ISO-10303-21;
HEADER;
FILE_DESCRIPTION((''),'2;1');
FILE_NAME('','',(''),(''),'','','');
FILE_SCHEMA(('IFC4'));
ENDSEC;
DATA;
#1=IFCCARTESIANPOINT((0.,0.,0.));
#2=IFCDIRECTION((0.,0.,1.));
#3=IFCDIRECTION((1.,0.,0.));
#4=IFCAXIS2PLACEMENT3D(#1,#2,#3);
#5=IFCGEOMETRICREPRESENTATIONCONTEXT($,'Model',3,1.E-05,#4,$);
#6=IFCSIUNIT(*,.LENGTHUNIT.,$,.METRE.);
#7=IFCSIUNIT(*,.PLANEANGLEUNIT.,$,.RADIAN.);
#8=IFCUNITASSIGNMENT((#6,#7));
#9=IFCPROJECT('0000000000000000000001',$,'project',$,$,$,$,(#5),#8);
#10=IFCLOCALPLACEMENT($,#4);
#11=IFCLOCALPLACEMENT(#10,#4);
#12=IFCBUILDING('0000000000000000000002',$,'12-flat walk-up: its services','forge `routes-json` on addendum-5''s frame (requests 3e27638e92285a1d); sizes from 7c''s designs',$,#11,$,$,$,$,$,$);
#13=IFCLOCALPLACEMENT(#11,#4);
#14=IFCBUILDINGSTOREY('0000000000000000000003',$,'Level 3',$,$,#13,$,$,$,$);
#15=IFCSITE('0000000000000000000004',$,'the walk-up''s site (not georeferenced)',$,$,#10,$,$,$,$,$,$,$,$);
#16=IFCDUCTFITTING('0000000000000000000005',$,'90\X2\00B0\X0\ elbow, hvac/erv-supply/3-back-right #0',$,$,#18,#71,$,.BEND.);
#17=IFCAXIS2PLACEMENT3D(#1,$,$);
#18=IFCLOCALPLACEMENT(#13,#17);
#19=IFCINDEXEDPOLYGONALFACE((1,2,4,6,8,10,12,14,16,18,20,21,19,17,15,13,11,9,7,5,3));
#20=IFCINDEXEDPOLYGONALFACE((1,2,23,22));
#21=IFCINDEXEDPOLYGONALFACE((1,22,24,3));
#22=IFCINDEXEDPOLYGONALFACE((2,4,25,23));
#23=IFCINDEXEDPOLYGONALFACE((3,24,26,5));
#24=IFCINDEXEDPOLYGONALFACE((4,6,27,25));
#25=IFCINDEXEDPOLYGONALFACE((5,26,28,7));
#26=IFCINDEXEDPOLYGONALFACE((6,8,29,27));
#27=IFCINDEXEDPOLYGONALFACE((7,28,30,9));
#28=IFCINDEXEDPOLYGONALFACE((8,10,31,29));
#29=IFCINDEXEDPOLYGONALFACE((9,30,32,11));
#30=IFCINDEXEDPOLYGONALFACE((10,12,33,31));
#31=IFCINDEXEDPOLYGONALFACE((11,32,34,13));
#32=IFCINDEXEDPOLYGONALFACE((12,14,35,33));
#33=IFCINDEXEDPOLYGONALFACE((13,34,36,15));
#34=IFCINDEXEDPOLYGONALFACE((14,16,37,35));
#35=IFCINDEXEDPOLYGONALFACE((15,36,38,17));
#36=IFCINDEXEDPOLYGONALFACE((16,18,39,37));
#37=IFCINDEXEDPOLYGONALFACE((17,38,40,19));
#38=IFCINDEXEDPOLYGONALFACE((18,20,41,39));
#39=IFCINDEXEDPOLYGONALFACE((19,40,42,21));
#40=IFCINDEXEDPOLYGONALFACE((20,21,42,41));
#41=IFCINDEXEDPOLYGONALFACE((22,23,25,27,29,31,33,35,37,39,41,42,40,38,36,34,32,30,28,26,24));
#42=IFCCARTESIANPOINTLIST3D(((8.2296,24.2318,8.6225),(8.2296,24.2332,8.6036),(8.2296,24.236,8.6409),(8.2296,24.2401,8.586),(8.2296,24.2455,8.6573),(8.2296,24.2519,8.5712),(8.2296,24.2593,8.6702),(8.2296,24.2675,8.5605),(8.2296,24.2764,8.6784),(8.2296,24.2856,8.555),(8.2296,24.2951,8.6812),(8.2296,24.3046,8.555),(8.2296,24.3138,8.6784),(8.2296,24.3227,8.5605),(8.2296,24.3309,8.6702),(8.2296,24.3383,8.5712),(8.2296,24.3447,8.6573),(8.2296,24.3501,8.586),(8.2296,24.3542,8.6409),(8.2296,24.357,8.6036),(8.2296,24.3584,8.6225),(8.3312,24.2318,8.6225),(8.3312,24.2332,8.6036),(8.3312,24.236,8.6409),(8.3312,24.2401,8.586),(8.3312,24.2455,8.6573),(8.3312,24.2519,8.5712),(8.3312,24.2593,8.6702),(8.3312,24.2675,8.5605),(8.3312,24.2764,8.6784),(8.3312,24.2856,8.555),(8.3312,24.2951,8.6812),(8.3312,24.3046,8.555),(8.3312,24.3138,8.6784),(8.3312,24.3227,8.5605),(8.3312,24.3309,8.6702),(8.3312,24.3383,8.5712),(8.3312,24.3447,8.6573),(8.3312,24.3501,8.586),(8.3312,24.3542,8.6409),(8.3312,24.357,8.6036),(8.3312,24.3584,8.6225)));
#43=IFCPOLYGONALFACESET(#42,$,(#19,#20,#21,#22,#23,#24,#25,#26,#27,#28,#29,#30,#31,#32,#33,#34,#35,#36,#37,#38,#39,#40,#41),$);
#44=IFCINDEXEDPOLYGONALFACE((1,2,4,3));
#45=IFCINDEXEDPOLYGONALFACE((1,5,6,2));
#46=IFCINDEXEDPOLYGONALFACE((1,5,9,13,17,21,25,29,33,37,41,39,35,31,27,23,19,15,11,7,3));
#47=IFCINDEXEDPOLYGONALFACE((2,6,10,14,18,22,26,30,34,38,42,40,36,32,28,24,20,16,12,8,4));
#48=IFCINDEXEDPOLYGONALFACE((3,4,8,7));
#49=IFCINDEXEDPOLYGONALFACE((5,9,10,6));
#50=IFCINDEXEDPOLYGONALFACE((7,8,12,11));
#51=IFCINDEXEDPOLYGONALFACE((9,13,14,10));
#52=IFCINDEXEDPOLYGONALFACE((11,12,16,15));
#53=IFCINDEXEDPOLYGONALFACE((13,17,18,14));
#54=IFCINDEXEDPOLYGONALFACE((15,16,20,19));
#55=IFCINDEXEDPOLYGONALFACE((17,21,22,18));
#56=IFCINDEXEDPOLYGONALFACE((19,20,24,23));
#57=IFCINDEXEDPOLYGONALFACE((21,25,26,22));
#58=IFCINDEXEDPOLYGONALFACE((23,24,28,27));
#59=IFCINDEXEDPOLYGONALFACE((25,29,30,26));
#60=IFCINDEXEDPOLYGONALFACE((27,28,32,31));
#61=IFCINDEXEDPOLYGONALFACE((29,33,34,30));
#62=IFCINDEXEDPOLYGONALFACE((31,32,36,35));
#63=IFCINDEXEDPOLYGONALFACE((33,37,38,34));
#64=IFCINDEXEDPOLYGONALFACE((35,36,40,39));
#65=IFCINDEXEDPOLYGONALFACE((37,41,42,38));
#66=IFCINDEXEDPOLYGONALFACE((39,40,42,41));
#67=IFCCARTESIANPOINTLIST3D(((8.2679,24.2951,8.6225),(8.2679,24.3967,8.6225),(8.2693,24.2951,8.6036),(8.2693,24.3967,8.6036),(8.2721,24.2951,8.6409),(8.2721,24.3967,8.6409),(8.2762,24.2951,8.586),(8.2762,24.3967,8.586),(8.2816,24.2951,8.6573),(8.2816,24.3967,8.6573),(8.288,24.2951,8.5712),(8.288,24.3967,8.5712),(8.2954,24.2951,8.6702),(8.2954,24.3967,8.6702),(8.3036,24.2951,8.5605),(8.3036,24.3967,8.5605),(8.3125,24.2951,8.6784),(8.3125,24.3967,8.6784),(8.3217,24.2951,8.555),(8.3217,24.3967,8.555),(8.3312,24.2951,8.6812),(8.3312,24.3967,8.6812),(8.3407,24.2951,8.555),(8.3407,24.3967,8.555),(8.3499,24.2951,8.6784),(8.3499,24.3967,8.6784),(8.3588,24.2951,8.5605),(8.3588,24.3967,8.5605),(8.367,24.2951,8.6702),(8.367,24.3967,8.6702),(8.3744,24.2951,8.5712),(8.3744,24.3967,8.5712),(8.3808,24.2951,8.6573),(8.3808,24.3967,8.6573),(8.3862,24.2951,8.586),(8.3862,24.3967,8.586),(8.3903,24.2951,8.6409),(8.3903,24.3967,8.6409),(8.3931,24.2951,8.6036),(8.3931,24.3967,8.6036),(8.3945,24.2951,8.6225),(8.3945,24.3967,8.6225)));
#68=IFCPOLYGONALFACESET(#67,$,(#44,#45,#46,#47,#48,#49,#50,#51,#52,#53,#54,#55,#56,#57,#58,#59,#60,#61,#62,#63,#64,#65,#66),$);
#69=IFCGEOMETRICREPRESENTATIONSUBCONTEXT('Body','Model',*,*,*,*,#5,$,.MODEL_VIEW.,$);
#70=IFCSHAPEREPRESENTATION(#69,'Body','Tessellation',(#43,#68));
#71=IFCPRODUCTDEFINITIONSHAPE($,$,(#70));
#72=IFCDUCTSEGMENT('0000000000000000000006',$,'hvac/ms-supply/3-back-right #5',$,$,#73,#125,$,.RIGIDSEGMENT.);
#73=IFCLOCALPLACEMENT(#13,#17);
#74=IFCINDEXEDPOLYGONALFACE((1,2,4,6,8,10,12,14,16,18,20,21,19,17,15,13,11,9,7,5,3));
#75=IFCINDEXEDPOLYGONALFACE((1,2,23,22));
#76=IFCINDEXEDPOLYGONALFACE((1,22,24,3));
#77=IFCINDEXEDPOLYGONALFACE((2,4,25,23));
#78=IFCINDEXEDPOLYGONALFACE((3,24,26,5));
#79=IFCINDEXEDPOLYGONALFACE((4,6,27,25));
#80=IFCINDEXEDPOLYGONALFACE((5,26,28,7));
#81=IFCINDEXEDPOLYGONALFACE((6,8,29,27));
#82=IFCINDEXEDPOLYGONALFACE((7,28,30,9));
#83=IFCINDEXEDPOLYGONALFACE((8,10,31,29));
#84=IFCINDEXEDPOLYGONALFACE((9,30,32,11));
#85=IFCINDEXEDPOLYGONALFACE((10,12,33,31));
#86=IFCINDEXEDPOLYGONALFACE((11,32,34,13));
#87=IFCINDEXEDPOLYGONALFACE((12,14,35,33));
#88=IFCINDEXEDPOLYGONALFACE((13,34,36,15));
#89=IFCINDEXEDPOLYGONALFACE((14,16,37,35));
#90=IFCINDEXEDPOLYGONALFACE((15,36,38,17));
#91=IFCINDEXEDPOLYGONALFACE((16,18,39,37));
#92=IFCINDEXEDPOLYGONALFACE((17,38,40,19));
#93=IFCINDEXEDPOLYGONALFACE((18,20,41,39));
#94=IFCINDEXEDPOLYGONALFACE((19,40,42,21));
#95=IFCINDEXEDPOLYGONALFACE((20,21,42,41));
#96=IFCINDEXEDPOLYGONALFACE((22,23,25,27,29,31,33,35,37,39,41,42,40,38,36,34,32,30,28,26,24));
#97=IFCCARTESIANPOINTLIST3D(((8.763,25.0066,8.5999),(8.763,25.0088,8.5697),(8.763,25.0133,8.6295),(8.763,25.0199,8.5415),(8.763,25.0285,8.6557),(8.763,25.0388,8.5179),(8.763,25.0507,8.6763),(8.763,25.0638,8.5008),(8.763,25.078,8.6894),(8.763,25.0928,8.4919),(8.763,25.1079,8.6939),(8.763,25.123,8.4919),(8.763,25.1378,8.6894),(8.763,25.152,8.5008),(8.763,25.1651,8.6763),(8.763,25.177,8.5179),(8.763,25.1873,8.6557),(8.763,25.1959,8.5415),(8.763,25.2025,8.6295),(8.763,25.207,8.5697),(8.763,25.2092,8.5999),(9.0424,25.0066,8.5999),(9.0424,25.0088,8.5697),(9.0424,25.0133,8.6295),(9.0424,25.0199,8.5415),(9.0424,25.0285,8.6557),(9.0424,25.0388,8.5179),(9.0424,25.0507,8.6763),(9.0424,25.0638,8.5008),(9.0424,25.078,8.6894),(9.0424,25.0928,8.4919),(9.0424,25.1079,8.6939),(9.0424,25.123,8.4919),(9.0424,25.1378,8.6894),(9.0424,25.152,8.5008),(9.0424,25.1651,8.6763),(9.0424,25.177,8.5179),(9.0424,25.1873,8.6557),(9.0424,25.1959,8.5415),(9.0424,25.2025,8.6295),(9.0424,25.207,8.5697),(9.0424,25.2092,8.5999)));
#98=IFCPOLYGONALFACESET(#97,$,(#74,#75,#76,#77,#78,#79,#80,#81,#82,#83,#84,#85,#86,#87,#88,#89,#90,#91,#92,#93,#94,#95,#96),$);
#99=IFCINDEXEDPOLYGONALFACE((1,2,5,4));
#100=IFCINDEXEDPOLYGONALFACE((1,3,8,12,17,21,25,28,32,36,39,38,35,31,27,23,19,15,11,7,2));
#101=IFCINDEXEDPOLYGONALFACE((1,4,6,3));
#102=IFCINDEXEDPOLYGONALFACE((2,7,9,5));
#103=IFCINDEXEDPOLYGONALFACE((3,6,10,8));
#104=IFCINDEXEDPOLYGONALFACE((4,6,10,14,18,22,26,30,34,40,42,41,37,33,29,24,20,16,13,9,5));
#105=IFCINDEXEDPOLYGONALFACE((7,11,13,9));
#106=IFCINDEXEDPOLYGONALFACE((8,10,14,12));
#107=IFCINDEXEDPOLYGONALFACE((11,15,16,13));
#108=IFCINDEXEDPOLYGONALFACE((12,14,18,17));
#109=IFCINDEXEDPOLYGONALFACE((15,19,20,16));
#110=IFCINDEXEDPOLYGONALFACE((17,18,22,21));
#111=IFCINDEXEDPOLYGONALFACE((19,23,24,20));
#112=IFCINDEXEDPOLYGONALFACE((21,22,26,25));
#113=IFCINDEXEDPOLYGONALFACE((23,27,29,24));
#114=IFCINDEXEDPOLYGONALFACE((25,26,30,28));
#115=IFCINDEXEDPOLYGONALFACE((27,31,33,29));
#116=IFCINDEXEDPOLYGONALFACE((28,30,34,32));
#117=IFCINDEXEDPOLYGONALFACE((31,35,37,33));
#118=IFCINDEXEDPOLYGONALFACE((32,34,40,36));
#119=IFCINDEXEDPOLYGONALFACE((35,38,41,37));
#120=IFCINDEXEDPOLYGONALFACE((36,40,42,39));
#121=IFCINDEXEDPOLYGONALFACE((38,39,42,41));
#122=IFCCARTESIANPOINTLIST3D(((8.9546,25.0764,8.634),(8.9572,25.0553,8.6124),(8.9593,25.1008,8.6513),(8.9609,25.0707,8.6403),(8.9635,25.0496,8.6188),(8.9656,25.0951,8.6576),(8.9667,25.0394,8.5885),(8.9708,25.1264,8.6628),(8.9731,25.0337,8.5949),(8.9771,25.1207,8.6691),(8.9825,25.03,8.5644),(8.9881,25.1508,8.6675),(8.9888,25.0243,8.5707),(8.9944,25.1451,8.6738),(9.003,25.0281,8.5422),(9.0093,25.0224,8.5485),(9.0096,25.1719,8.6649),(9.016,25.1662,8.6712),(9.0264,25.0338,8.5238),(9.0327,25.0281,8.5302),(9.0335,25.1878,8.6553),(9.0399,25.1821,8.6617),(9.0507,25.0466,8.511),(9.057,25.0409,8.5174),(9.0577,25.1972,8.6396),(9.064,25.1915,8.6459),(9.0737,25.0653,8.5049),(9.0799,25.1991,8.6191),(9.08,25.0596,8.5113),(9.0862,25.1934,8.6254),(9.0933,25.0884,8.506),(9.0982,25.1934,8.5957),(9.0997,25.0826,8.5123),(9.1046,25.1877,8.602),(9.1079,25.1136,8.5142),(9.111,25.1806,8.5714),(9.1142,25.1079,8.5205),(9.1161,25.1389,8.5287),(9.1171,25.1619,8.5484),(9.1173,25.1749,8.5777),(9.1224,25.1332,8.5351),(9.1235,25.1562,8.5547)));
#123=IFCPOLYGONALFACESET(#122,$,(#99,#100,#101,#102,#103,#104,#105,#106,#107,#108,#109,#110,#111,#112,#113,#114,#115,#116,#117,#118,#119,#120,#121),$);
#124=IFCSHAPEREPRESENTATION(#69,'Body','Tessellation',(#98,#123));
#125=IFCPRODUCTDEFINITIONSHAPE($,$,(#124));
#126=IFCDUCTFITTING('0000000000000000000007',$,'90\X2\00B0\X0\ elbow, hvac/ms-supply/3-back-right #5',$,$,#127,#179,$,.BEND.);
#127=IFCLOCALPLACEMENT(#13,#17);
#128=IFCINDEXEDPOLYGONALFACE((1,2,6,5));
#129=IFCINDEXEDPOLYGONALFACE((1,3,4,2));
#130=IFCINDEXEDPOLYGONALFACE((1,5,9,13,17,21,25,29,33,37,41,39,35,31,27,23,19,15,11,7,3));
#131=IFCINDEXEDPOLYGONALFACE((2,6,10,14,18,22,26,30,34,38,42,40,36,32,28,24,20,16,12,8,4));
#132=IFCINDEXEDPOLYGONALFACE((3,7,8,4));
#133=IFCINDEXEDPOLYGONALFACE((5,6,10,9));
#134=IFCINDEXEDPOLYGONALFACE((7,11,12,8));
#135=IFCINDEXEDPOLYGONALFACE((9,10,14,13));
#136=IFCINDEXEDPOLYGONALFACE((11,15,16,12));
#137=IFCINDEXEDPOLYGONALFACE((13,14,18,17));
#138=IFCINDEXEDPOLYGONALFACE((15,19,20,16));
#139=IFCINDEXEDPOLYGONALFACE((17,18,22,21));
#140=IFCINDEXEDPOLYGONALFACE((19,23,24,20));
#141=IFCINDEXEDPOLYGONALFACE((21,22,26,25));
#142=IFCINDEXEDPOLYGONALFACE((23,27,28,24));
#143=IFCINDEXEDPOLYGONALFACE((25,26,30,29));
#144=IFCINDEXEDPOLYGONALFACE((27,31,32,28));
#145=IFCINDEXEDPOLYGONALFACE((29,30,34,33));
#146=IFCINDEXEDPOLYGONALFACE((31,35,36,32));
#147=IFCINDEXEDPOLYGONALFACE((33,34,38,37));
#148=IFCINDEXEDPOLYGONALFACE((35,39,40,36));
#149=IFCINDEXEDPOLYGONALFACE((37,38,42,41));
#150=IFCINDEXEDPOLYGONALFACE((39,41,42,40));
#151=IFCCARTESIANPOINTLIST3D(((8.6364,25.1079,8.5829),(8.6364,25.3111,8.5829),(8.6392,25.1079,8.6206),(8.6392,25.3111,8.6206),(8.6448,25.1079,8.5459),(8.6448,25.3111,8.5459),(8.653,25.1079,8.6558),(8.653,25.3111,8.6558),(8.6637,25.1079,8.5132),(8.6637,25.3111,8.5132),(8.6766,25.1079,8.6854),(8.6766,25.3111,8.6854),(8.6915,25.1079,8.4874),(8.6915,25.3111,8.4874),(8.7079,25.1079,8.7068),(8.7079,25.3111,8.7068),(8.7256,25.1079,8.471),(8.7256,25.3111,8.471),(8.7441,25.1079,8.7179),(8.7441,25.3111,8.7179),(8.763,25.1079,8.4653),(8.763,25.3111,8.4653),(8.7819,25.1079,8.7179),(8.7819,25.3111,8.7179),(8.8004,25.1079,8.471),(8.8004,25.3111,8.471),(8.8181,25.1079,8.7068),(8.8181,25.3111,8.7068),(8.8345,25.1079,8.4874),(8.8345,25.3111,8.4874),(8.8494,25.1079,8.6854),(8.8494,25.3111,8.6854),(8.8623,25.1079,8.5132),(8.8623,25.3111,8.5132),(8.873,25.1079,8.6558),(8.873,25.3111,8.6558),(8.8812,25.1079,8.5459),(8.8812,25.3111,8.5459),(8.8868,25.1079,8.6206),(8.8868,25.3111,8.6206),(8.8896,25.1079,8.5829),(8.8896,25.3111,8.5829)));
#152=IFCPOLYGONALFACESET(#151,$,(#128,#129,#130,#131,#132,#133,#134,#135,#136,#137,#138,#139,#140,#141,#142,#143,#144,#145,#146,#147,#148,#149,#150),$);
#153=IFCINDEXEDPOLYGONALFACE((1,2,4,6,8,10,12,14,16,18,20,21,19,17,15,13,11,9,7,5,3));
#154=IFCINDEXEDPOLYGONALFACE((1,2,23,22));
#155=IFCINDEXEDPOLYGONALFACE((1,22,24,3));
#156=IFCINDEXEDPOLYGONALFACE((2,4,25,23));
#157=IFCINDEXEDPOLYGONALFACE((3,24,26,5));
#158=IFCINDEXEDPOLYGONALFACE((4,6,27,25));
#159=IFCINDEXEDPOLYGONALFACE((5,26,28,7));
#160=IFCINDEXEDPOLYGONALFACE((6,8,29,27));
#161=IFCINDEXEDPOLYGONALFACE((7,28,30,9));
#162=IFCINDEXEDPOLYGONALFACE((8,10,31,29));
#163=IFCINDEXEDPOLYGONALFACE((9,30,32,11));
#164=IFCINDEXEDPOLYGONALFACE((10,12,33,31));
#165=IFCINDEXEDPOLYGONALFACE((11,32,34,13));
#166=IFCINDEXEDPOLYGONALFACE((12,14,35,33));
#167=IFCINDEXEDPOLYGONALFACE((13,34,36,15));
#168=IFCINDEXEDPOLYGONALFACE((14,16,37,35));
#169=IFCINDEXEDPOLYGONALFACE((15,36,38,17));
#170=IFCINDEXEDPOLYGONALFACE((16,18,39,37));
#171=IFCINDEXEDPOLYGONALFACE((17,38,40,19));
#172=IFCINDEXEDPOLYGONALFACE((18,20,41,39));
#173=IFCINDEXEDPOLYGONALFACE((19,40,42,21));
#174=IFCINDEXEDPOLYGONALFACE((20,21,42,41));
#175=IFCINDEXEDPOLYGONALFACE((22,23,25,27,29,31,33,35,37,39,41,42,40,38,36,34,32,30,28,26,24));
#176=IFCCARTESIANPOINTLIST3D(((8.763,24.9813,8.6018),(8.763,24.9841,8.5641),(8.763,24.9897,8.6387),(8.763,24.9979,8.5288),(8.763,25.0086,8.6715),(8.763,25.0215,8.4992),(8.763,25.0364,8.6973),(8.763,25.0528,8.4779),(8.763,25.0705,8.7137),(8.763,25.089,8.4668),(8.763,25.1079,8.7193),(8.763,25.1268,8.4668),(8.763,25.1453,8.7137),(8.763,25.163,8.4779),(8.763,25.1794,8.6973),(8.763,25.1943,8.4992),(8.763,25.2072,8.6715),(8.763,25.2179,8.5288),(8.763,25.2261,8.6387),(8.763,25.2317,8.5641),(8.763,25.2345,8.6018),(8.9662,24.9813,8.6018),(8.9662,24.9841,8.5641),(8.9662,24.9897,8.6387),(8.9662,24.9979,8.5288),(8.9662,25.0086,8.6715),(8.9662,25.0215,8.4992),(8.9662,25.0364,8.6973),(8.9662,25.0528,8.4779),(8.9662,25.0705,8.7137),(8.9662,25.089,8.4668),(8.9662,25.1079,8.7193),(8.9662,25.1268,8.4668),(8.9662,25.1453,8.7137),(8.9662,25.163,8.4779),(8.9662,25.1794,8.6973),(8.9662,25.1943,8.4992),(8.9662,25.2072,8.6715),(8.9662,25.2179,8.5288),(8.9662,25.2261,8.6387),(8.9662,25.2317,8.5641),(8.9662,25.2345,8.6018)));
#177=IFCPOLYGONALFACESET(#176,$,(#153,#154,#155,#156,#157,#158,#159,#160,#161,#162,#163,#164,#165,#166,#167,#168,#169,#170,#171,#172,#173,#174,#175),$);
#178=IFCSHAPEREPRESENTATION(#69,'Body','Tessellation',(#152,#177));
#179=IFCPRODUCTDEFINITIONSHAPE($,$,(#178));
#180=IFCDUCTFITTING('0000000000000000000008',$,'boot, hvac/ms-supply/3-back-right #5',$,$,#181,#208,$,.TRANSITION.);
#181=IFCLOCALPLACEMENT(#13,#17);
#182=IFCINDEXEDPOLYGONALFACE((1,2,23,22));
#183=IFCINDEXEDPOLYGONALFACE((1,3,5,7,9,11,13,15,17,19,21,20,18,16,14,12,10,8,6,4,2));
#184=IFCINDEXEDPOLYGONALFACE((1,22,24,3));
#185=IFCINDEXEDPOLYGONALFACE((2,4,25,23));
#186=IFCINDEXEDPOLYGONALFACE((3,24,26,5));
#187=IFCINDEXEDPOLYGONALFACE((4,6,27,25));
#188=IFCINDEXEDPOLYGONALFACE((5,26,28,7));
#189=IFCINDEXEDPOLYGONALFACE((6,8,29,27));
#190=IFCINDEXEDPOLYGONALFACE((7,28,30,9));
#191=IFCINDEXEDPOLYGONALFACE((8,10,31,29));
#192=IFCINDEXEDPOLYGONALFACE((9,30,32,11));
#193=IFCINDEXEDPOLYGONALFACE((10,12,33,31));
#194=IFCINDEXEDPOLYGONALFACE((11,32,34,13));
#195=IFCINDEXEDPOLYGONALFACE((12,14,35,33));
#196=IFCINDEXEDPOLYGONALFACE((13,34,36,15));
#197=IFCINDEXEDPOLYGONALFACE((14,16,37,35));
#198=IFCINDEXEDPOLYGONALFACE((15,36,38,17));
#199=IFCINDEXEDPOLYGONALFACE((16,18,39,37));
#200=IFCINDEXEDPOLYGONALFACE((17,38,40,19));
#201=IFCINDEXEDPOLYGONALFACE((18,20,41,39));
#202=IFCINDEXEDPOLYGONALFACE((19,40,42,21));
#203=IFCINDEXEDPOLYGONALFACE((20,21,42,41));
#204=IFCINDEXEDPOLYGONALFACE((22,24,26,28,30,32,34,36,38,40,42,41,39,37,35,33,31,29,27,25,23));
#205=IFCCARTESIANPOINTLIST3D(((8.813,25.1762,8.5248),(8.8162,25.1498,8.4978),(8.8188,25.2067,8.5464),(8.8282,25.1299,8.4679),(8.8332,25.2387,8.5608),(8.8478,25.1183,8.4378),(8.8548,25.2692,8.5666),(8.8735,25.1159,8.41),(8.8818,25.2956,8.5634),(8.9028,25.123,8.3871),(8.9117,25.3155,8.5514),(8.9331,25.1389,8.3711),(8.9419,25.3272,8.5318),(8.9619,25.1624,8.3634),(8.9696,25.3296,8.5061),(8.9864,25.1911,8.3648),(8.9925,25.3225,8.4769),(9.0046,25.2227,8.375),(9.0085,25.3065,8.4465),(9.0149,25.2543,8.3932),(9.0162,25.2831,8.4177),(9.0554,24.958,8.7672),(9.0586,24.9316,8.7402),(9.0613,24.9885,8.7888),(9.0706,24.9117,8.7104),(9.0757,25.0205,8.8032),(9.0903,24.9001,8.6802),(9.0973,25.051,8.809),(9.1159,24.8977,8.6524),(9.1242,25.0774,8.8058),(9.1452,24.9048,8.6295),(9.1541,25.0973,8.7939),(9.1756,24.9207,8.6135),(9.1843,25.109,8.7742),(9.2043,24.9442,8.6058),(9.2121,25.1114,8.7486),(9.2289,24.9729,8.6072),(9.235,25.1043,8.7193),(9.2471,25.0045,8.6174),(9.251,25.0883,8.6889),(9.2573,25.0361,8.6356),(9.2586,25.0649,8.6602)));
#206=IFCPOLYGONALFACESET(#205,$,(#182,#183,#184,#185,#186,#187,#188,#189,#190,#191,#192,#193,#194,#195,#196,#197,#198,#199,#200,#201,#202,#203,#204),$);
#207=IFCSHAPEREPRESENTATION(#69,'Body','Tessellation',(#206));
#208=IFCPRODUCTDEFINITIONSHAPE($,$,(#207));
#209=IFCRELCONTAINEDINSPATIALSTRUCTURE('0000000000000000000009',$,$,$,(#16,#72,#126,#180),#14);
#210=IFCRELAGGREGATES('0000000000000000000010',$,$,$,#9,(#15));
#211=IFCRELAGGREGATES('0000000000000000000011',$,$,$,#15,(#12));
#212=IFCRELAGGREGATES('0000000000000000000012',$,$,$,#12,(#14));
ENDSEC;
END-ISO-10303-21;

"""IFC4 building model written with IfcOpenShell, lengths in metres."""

from ifc_helpers import new_model, entity, si_unit, frame, origin_with_axes, place, context, subcontext, project, spatial, element, save


model = new_model("IFC4")

# Units and contexts
model_context = context("Model", 3, precision=1e-05, world=origin_with_axes())
body_context = subcontext(model_context, "Body", "Model", "MODEL_VIEW")
ifc_project = project(units=[si_unit("LENGTHUNIT", "METRE"), si_unit("PLANEANGLEUNIT", "RADIAN")], contexts=[model_context])

# Site, building, storey
site_placement = place(None, origin_with_axes())
site = spatial("IfcSite", under=ifc_project, at=site_placement, Name="the walk-up's site (not georeferenced)")
building_placement = place(site_placement, origin_with_axes())
building = spatial("IfcBuilding", under=site, at=building_placement, Name="12-flat walk-up: its services", Description="forge `routes-json` on addendum-5's frame (requests 3e27638e92285a1d); sizes from 7c's designs")
storey_placement = place(building_placement, origin_with_axes())
storey = spatial("IfcBuildingStorey", under=building, at=storey_placement, Name="Level 3")

# Duct fitting
duct_fitting_1_placement = place(storey_placement, frame((8.2296, 24.2951, 8.6177), z_axis=(0.0, 0.0, 1.0), x_axis=(1.0, 0.0, 0.0)))
element("IfcDuctFitting", 1, at=duct_fitting_1_placement, inside=storey, Name="90° elbow, hvac/erv-supply/3-back-right #0", PredefinedType="BEND", context=body_context, shape_type="AdvancedSweptSolid", body=[
    entity("IfcSweptDiskSolid", entity("IfcPolyline", [entity("IfcCartesianPoint", [0.0, 0.0, 0.0]), entity("IfcCartesianPoint", [0.1016, 0.0, 0.0])]), 0.0635),
    entity("IfcSweptDiskSolid", entity("IfcPolyline", [entity("IfcCartesianPoint", [0.1016, 0.0, 0.0]), entity("IfcCartesianPoint", [0.1016, 0.1016, 0.0])]), 0.0635),
])

# Duct segment
duct_segment_1_placement = place(storey_placement, frame((8.763, 25.1079, 8.5923), z_axis=(0.0, 0.0, 1.0), x_axis=(1.0, 0.0, 0.0)))
element("IfcDuctSegment", 2, at=duct_segment_1_placement, inside=storey, Name="hvac/ms-supply/3-back-right #5", PredefinedType="RIGIDSEGMENT", context=body_context, shape_type="AdvancedSweptSolid", body=[
    entity("IfcSweptDiskSolid", entity("IfcPolyline", [entity("IfcCartesianPoint", [0.0, 0.0, 0.0]), entity("IfcCartesianPoint", [0.2794, 0.0, 0.0])]), 0.1016),
    entity("IfcSweptDiskSolid", entity("IfcPolyline", [entity("IfcCartesianPoint", [0.2794, 0.0, 0.0]), entity("IfcCartesianPoint", [0.273, 0.0057, -0.0063])]), 0.1016),
])

# Duct fittings
duct_fitting_2_placement = place(storey_placement, frame((8.763, 25.3111, 8.5923), z_axis=(0.0, 0.0, 1.0), x_axis=(1.0, 0.0, 0.0)))
element("IfcDuctFitting", 3, at=duct_fitting_2_placement, inside=storey, Name="90° elbow, hvac/ms-supply/3-back-right #5", PredefinedType="BEND", context=body_context, shape_type="AdvancedSweptSolid", body=[
    entity("IfcSweptDiskSolid", entity("IfcPolyline", [entity("IfcCartesianPoint", [0.0, 0.0, 0.0]), entity("IfcCartesianPoint", [0.0, -0.2032, 0.0])]), 0.127),
    entity("IfcSweptDiskSolid", entity("IfcPolyline", [entity("IfcCartesianPoint", [0.0, -0.2032, 0.0]), entity("IfcCartesianPoint", [0.2032, -0.2032, 0.0])]), 0.127),
])
duct_fitting_3_placement = place(storey_placement, frame((9.1573, 25.0045, 8.7072), z_axis=(0.0, 0.0, 1.0), x_axis=(1.0, 0.0, 0.0)))
element("IfcDuctFitting", 4, at=duct_fitting_3_placement, inside=storey, Name="boot, hvac/ms-supply/3-back-right #5", PredefinedType="TRANSITION", context=body_context, shape_type="AdvancedSweptSolid", body=[
    entity("IfcSweptDiskSolid", entity("IfcPolyline", [entity("IfcCartesianPoint", [0.0, 0.0, 0.0]), entity("IfcCartesianPoint", [-0.2424, 0.2182, -0.2424])]), 0.127),
])

save(model, "model.ifc")
